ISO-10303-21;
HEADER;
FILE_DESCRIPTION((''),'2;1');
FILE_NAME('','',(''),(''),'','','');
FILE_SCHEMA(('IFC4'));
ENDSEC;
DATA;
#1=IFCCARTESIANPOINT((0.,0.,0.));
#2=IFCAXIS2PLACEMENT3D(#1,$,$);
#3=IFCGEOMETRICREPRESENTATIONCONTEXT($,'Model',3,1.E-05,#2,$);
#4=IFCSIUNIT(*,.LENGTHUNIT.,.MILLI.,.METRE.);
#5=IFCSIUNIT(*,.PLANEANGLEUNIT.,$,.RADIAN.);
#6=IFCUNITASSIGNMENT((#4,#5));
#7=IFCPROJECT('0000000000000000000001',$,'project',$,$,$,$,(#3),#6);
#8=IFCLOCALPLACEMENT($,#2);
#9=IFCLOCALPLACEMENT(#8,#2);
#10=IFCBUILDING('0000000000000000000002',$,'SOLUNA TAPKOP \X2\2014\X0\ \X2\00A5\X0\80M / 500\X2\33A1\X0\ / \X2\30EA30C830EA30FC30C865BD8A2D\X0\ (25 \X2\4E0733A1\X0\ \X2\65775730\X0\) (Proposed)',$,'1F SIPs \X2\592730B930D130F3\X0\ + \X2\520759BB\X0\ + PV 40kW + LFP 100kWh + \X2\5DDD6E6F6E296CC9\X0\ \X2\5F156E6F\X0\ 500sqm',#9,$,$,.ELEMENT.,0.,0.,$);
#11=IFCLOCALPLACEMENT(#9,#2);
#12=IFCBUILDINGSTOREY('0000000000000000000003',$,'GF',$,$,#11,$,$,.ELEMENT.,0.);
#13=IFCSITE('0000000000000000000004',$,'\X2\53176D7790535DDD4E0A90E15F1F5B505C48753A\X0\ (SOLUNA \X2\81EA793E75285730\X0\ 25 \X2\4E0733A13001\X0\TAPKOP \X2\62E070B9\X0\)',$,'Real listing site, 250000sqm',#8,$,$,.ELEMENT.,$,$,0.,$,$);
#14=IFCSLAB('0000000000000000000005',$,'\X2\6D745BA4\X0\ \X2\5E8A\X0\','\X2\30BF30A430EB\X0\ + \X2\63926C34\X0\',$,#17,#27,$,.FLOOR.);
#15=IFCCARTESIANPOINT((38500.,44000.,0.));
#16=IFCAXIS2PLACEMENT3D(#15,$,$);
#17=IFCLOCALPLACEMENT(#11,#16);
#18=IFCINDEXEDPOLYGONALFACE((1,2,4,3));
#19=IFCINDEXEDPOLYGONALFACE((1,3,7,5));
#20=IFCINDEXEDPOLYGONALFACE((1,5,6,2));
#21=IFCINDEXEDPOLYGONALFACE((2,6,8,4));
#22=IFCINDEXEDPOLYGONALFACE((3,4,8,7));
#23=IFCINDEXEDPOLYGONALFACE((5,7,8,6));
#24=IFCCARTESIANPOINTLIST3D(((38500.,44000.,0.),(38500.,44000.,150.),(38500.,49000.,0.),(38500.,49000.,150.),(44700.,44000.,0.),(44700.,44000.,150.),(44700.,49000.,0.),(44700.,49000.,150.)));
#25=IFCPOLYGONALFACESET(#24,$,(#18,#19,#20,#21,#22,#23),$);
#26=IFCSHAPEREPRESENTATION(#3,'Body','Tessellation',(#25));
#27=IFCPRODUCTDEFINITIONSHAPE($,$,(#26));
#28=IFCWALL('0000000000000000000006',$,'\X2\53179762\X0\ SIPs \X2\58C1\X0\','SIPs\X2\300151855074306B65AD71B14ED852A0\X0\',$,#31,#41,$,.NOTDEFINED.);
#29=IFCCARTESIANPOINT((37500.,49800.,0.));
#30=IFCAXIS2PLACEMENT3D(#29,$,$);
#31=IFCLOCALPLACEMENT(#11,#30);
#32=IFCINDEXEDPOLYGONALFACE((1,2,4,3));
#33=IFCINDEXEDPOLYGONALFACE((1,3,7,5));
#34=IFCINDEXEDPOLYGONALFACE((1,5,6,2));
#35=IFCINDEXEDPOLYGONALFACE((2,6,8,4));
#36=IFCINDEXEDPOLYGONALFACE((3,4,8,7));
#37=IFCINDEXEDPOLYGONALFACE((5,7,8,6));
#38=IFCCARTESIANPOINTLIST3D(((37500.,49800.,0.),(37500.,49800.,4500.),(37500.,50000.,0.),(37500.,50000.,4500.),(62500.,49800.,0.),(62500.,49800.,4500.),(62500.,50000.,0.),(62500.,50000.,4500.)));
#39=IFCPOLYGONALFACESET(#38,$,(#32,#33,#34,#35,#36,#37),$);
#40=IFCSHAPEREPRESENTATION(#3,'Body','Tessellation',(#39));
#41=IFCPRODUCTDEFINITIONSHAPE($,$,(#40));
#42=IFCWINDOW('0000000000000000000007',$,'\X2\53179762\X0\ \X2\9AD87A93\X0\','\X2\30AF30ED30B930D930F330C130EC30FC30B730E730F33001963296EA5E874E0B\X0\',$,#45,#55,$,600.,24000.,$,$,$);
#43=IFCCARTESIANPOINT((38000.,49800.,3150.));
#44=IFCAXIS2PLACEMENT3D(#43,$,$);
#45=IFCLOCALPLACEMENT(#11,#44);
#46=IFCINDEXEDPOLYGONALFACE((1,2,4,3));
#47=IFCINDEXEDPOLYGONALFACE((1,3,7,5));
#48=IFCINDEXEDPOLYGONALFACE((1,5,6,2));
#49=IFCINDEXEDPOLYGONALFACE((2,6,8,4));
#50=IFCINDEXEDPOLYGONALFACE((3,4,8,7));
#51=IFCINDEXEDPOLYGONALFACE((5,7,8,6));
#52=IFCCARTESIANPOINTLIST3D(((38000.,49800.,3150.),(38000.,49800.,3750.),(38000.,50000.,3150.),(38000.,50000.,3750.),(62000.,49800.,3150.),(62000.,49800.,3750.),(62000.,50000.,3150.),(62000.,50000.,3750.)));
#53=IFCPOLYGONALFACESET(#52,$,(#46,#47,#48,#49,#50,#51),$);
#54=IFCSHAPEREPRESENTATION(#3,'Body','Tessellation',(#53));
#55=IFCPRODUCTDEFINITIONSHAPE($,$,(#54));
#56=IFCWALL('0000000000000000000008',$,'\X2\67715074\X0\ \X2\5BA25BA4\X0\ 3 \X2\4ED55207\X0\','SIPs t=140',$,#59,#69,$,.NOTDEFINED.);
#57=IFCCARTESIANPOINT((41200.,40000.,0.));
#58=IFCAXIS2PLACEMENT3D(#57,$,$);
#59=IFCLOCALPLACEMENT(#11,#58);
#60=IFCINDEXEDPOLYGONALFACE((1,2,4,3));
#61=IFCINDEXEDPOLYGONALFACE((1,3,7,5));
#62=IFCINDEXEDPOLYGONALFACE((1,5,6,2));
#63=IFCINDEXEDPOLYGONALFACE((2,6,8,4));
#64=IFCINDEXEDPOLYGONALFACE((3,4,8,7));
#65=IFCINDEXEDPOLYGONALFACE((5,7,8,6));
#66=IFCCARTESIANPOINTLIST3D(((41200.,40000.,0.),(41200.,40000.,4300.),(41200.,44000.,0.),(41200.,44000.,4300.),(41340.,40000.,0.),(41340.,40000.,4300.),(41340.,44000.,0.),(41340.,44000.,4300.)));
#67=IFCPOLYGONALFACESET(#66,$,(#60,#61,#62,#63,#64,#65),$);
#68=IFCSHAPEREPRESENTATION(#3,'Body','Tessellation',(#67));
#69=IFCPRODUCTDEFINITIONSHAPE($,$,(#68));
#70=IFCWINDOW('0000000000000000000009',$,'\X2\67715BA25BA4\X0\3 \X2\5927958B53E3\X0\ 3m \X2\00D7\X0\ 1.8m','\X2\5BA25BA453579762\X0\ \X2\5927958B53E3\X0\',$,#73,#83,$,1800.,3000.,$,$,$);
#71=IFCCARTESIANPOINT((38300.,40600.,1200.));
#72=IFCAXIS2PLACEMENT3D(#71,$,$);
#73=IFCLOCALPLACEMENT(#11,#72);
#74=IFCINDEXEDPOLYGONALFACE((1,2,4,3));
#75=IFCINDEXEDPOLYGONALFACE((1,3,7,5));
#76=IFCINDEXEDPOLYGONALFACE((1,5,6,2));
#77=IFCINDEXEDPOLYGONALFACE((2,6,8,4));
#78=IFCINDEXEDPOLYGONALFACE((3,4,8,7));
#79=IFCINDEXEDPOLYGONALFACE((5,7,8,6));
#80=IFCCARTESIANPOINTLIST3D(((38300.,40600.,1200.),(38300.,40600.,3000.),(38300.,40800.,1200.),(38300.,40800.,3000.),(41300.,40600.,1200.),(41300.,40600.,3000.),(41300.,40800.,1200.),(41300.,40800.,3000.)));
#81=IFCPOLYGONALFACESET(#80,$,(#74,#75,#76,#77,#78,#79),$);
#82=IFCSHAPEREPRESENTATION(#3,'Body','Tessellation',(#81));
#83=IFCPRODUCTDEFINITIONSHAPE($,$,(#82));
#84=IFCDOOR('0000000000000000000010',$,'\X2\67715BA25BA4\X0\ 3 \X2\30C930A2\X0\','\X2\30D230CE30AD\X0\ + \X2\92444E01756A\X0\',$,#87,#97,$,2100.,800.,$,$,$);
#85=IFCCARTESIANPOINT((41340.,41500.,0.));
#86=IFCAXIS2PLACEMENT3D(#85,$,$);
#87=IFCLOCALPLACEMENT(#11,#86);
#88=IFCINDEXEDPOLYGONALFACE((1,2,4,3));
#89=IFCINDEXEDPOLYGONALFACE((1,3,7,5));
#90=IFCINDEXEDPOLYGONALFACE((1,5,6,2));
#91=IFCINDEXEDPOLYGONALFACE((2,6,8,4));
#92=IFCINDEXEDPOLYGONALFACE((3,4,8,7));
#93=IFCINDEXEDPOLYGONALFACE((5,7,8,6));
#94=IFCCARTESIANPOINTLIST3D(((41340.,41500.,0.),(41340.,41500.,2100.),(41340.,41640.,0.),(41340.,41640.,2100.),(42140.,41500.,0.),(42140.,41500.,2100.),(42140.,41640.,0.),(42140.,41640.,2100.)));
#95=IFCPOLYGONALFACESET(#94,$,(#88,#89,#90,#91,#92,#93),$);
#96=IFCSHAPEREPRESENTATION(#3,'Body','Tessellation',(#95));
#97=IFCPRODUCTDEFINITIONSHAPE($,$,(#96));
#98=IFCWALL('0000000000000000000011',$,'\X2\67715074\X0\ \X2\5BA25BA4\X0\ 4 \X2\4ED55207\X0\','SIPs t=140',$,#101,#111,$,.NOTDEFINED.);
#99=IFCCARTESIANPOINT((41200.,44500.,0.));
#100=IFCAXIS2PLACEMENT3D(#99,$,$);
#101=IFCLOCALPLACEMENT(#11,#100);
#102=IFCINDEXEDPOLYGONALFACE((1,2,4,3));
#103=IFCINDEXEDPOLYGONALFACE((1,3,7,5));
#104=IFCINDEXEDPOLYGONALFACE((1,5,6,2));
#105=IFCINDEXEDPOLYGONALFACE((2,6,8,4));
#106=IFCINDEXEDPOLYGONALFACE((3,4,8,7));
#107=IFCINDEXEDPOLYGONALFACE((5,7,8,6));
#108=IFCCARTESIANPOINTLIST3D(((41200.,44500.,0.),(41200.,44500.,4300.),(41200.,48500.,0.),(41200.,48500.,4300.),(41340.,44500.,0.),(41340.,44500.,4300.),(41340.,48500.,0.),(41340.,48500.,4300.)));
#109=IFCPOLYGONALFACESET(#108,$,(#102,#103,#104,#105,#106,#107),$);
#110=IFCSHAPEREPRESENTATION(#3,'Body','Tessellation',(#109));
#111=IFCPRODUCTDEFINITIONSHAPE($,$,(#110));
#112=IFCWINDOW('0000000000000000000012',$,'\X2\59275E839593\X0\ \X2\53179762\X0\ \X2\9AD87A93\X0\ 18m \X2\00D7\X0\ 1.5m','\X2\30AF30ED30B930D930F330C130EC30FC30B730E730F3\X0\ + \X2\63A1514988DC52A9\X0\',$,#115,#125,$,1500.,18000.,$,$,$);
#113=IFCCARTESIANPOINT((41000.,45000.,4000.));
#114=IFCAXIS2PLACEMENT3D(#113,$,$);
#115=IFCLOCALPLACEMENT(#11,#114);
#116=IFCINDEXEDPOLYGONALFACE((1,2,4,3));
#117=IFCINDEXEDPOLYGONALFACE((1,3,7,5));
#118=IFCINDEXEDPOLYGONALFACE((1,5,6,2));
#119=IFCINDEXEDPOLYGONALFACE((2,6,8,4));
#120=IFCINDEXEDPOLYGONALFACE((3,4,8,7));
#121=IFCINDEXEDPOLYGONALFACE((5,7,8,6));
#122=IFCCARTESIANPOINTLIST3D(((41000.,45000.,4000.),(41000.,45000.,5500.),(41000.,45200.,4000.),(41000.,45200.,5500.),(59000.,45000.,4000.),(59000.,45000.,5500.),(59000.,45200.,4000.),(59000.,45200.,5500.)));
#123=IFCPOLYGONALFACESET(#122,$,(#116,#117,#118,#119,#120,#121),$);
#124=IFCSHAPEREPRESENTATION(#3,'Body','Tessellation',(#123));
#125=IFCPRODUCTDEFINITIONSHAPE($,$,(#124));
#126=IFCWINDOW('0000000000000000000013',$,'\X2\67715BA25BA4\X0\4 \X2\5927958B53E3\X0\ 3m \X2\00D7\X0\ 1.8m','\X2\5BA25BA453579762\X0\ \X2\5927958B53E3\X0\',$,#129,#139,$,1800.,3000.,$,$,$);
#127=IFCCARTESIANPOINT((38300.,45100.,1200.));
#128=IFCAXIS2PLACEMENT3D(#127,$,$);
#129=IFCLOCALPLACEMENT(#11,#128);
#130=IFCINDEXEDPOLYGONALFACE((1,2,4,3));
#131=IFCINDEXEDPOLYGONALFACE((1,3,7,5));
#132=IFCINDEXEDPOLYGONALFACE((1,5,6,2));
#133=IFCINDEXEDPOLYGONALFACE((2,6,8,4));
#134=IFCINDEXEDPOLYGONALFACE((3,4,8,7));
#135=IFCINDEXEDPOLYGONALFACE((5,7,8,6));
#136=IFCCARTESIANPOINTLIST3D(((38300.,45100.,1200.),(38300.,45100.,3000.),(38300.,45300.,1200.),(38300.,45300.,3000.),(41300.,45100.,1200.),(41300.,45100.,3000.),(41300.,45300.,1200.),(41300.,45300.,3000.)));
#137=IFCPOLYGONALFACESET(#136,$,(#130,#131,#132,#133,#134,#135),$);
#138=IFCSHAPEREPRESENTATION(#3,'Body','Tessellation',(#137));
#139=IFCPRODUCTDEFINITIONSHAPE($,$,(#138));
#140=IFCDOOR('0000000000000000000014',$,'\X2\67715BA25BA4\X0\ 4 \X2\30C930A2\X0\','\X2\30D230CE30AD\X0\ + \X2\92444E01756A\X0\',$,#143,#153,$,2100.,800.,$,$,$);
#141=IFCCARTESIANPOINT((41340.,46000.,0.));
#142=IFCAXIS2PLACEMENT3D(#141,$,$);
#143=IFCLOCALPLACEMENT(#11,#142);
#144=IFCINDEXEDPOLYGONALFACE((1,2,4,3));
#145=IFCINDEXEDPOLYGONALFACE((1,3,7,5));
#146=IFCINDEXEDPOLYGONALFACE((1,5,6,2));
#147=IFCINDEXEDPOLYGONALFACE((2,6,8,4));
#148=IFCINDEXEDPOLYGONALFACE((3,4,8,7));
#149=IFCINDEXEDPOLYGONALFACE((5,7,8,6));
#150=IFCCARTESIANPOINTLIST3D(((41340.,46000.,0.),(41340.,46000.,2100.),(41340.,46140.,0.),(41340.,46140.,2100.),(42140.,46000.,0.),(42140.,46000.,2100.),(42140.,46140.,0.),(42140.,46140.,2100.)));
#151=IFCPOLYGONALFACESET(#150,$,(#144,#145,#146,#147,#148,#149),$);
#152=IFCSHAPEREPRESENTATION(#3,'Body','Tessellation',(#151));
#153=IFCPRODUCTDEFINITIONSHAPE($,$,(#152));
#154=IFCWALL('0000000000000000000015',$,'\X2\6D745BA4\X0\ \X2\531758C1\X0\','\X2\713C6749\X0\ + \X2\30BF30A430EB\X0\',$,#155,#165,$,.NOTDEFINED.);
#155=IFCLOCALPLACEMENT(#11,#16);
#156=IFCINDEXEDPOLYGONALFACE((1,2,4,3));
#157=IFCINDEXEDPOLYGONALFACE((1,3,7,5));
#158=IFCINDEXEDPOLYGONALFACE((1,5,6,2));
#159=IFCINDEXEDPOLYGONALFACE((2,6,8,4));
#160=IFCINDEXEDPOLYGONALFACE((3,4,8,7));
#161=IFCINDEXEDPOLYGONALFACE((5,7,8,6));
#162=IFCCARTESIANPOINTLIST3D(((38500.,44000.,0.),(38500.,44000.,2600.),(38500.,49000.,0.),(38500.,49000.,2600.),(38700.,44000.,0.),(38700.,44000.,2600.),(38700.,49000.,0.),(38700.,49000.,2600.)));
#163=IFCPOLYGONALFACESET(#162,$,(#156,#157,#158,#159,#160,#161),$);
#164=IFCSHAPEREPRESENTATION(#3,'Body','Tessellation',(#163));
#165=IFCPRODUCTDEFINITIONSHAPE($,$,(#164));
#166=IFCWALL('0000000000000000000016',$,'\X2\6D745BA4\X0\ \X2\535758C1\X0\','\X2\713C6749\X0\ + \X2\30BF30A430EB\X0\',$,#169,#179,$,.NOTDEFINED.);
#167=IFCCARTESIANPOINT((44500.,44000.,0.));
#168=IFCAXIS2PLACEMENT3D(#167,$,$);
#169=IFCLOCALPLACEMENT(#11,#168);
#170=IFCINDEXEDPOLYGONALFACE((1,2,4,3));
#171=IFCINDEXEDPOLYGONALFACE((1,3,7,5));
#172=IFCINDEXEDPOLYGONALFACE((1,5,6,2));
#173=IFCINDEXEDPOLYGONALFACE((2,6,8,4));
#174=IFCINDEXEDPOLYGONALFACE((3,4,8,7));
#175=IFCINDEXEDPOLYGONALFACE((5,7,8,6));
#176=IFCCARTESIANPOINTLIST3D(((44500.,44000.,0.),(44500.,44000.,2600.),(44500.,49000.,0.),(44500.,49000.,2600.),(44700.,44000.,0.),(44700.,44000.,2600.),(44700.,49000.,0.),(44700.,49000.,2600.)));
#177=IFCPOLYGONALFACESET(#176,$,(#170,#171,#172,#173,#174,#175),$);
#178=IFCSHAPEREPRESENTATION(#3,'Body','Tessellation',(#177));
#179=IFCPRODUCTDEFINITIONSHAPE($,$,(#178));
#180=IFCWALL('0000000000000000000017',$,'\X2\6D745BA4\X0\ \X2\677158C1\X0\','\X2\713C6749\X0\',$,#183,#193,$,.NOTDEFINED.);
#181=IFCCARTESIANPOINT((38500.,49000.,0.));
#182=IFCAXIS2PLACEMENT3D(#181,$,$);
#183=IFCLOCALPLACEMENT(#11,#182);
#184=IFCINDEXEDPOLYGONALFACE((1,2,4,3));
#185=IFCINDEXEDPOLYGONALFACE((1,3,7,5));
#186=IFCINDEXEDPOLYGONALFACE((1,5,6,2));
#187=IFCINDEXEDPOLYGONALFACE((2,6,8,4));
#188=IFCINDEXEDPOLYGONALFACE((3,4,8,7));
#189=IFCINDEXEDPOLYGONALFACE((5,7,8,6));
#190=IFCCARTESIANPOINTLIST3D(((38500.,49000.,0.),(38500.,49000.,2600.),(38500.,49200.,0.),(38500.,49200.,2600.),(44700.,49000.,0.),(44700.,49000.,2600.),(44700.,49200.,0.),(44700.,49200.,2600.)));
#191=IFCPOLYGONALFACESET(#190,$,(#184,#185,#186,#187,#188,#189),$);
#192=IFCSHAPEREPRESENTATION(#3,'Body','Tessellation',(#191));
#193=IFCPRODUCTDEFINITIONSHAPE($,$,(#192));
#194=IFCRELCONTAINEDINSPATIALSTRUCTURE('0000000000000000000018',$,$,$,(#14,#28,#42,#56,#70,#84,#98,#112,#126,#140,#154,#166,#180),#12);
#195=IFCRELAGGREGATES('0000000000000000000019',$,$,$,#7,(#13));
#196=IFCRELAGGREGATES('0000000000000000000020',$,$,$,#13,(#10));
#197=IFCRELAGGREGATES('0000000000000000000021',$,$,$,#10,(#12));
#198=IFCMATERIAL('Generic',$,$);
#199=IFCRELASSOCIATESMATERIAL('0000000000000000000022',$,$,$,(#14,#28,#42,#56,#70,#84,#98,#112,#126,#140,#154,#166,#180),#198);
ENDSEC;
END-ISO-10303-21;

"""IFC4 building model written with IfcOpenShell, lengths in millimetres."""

from ifc_helpers import new_model, si_unit, frame, frame_2d, origin, place, context, project, spatial, rectangle, extrude, material, element, fill, save


model = new_model("IFC4")

# Units and contexts
model_context = context("Model", 3, precision=1e-05, world=origin())
ifc_project = project(units=[si_unit("LENGTHUNIT", "METRE", prefix="MILLI"), si_unit("PLANEANGLEUNIT", "RADIAN")], contexts=[model_context])

# Site, building, storey
site_placement = place(None, origin())
site = spatial("IfcSite", under=ifc_project, at=site_placement, Name="北海道川上郡弟子屈町 (SOLUNA 自社用地 25 万㎡、TAPKOP 拠点)", ObjectType="Real listing site, 250000sqm", CompositionType="ELEMENT", RefElevation=0.0)
building_placement = place(site_placement, origin())
building = spatial("IfcBuilding", under=site, at=building_placement, Name="SOLUNA TAPKOP — ¥80M / 500㎡ / リトリート施設 (25 万㎡ 敷地) (Proposed)", ObjectType="1F SIPs 大スパン + 切妻 + PV 40kW + LFP 100kWh + 川湯温泉 引湯 500sqm", CompositionType="ELEMENT", ElevationOfRefHeight=0.0, ElevationOfTerrain=0.0)
storey_placement = place(building_placement, origin())
storey = spatial("IfcBuildingStorey", under=building, at=storey_placement, Name="GF", CompositionType="ELEMENT", Elevation=0.0)

# Slab
ifc_material_1 = material(Name="Generic")
slab_placement = place(storey_placement, frame((38500.0, 44000.0, 0.0)))
element("IfcSlab", 1, at=slab_placement, inside=storey, material=ifc_material_1, Name="浴室 床", Description="タイル + 排水", PredefinedType="FLOOR", context=model_context, shape_type="SweptSolid", body=[
    extrude(rectangle(XDim=6200.0, YDim=5000.0, at=frame_2d((3100.0, 2500.0))), frame((38500.0, 44000.0, 0.0)), (0.0, 0.0, 1.0), 150.0),
])

# Walls, openings, windows
wall_1_placement = place(storey_placement, frame((37500.0, 49800.0, 0.0)))
wall_1 = element("IfcWall", 2, at=wall_1_placement, inside=storey, material=ifc_material_1, Name="北面 SIPs 壁", Description="SIPs、内側に断熱付加", PredefinedType="NOTDEFINED", context=model_context, shape_type="SweptSolid", body=[
    extrude(rectangle(XDim=25000.0, YDim=200.0, at=frame_2d((12500.0, 100.0))), frame((37500.0, 49800.0, 0.0)), (0.0, 0.0, 1.0), 4500.0),
])
opening_1_placement = place(storey_placement, frame((38000.0, 49800.0, 3150.0)))
opening_1 = element("IfcOpeningElement", 3, at=opening_1_placement, cuts=wall_1, PredefinedType="NOTDEFINED", context=model_context, shape_type="SweptSolid", body=[
    extrude(rectangle(XDim=24000.0, YDim=200.0, at=frame_2d((12000.0, 100.0))), frame((38000.0, 49800.0, 3150.0)), (0.0, 0.0, 1.0), 600.0),
])
window_1_placement = place(storey_placement, frame((38000.0, 49800.0, 3150.0)))
window_1 = element("IfcWindow", 4, at=window_1_placement, inside=storey, material=ifc_material_1, Name="北面 高窓", Description="クロスベンチレーション、防雪庇下", OverallHeight=600.0, OverallWidth=24000.0, context=model_context, shape_type="SweptSolid", body=[
    extrude(rectangle(XDim=24000.0, YDim=200.0, at=frame_2d((12000.0, 100.0))), frame((38000.0, 49800.0, 3150.0)), (0.0, 0.0, 1.0), 600.0),
])
fill(opening_1, window_1)
wall_2_placement = place(storey_placement, frame((41200.0, 40000.0, 0.0)))
wall_2 = element("IfcWall", 5, at=wall_2_placement, inside=storey, material=ifc_material_1, Name="東側 客室 3 仕切", Description="SIPs t=140", PredefinedType="NOTDEFINED", context=model_context, shape_type="SweptSolid", body=[
    extrude(rectangle(XDim=140.0, YDim=4000.0, at=frame_2d((70.0, 2000.0))), frame((41200.0, 40000.0, 0.0)), (0.0, 0.0, 1.0), 4300.0),
])
opening_2_placement = place(storey_placement, frame((38300.0, 40600.0, 1200.0)))
opening_2 = element("IfcOpeningElement", 6, at=opening_2_placement, cuts=wall_2, PredefinedType="NOTDEFINED", context=model_context, shape_type="SweptSolid", body=[
    extrude(rectangle(XDim=3000.0, YDim=200.0, at=frame_2d((1500.0, 100.0))), frame((38300.0, 40600.0, 1200.0)), (0.0, 0.0, 1.0), 1800.0),
])
window_2_placement = place(storey_placement, frame((38300.0, 40600.0, 1200.0)))
window_2 = element("IfcWindow", 7, at=window_2_placement, inside=storey, material=ifc_material_1, Name="東客室3 大開口 3m × 1.8m", Description="客室南面 大開口", OverallHeight=1800.0, OverallWidth=3000.0, context=model_context, shape_type="SweptSolid", body=[
    extrude(rectangle(XDim=3000.0, YDim=200.0, at=frame_2d((1500.0, 100.0))), frame((38300.0, 40600.0, 1200.0)), (0.0, 0.0, 1.0), 1800.0),
])
fill(opening_2, window_2)

# Door
door_1_placement = place(storey_placement, frame((41340.0, 41500.0, 0.0)))
element("IfcDoor", 8, at=door_1_placement, inside=storey, material=ifc_material_1, Name="東客室 3 ドア", Description="ヒノキ + 鉄丁番", OverallHeight=2100.0, OverallWidth=800.0, context=model_context, shape_type="SweptSolid", body=[
    extrude(rectangle(XDim=800.0, YDim=140.0, at=frame_2d((400.0, 70.0))), frame((41340.0, 41500.0, 0.0)), (0.0, 0.0, 1.0), 2100.0),
])

# Wall, openings, windows
wall_3_placement = place(storey_placement, frame((41200.0, 44500.0, 0.0)))
wall_3 = element("IfcWall", 9, at=wall_3_placement, inside=storey, material=ifc_material_1, Name="東側 客室 4 仕切", Description="SIPs t=140", PredefinedType="NOTDEFINED", context=model_context, shape_type="SweptSolid", body=[
    extrude(rectangle(XDim=140.0, YDim=4000.0, at=frame_2d((70.0, 2000.0))), frame((41200.0, 44500.0, 0.0)), (0.0, 0.0, 1.0), 4300.0),
])
opening_3_placement = place(storey_placement, frame((41000.0, 45000.0, 4000.0)))
opening_3 = element("IfcOpeningElement", 10, at=opening_3_placement, cuts=wall_3, PredefinedType="NOTDEFINED", context=model_context, shape_type="SweptSolid", body=[
    extrude(rectangle(XDim=18000.0, YDim=200.0, at=frame_2d((9000.0, 100.0))), frame((41000.0, 45000.0, 4000.0)), (0.0, 0.0, 1.0), 1500.0),
])
opening_4_placement = place(storey_placement, frame((38300.0, 45100.0, 1200.0)))
opening_4 = element("IfcOpeningElement", 11, at=opening_4_placement, cuts=wall_3, PredefinedType="NOTDEFINED", context=model_context, shape_type="SweptSolid", body=[
    extrude(rectangle(XDim=3000.0, YDim=200.0, at=frame_2d((1500.0, 100.0))), frame((38300.0, 45100.0, 1200.0)), (0.0, 0.0, 1.0), 1800.0),
])
window_3_placement = place(storey_placement, frame((41000.0, 45000.0, 4000.0)))
window_3 = element("IfcWindow", 12, at=window_3_placement, inside=storey, material=ifc_material_1, Name="大広間 北面 高窓 18m × 1.5m", Description="クロスベンチレーション + 採光補助", OverallHeight=1500.0, OverallWidth=18000.0, context=model_context, shape_type="SweptSolid", body=[
    extrude(rectangle(XDim=18000.0, YDim=200.0, at=frame_2d((9000.0, 100.0))), frame((41000.0, 45000.0, 4000.0)), (0.0, 0.0, 1.0), 1500.0),
])
fill(opening_3, window_3)
window_4_placement = place(storey_placement, frame((38300.0, 45100.0, 1200.0)))
window_4 = element("IfcWindow", 13, at=window_4_placement, inside=storey, material=ifc_material_1, Name="東客室4 大開口 3m × 1.8m", Description="客室南面 大開口", OverallHeight=1800.0, OverallWidth=3000.0, context=model_context, shape_type="SweptSolid", body=[
    extrude(rectangle(XDim=3000.0, YDim=200.0, at=frame_2d((1500.0, 100.0))), frame((38300.0, 45100.0, 1200.0)), (0.0, 0.0, 1.0), 1800.0),
])
fill(opening_4, window_4)

# Door
door_2_placement = place(storey_placement, frame((41340.0, 46000.0, 0.0)))
element("IfcDoor", 14, at=door_2_placement, inside=storey, material=ifc_material_1, Name="東客室 4 ドア", Description="ヒノキ + 鉄丁番", OverallHeight=2100.0, OverallWidth=800.0, context=model_context, shape_type="SweptSolid", body=[
    extrude(rectangle(XDim=800.0, YDim=140.0, at=frame_2d((400.0, 70.0))), frame((41340.0, 46000.0, 0.0)), (0.0, 0.0, 1.0), 2100.0),
])

# Walls
wall_4_placement = place(storey_placement, frame((38500.0, 44000.0, 0.0)))
element("IfcWall", 15, at=wall_4_placement, inside=storey, material=ifc_material_1, Name="浴室 北壁", Description="焼杉 + タイル", PredefinedType="NOTDEFINED", context=model_context, shape_type="SweptSolid", body=[
    extrude(rectangle(XDim=200.0, YDim=5000.0, at=frame_2d((100.0, 2500.0))), frame((38500.0, 44000.0, 0.0)), (0.0, 0.0, 1.0), 2600.0),
])
wall_5_placement = place(storey_placement, frame((44500.0, 44000.0, 0.0)))
element("IfcWall", 16, at=wall_5_placement, inside=storey, material=ifc_material_1, Name="浴室 南壁", Description="焼杉 + タイル", PredefinedType="NOTDEFINED", context=model_context, shape_type="SweptSolid", body=[
    extrude(rectangle(XDim=200.0, YDim=5000.0, at=frame_2d((100.0, 2500.0))), frame((44500.0, 44000.0, 0.0)), (0.0, 0.0, 1.0), 2600.0),
])
wall_6_placement = place(storey_placement, frame((38500.0, 49000.0, 0.0)))
element("IfcWall", 17, at=wall_6_placement, inside=storey, material=ifc_material_1, Name="浴室 東壁", Description="焼杉", PredefinedType="NOTDEFINED", context=model_context, shape_type="SweptSolid", body=[
    extrude(rectangle(XDim=6200.0, YDim=200.0, at=frame_2d((3100.0, 100.0))), frame((38500.0, 49000.0, 0.0)), (0.0, 0.0, 1.0), 2600.0),
])

save(model, "model.ifc")
